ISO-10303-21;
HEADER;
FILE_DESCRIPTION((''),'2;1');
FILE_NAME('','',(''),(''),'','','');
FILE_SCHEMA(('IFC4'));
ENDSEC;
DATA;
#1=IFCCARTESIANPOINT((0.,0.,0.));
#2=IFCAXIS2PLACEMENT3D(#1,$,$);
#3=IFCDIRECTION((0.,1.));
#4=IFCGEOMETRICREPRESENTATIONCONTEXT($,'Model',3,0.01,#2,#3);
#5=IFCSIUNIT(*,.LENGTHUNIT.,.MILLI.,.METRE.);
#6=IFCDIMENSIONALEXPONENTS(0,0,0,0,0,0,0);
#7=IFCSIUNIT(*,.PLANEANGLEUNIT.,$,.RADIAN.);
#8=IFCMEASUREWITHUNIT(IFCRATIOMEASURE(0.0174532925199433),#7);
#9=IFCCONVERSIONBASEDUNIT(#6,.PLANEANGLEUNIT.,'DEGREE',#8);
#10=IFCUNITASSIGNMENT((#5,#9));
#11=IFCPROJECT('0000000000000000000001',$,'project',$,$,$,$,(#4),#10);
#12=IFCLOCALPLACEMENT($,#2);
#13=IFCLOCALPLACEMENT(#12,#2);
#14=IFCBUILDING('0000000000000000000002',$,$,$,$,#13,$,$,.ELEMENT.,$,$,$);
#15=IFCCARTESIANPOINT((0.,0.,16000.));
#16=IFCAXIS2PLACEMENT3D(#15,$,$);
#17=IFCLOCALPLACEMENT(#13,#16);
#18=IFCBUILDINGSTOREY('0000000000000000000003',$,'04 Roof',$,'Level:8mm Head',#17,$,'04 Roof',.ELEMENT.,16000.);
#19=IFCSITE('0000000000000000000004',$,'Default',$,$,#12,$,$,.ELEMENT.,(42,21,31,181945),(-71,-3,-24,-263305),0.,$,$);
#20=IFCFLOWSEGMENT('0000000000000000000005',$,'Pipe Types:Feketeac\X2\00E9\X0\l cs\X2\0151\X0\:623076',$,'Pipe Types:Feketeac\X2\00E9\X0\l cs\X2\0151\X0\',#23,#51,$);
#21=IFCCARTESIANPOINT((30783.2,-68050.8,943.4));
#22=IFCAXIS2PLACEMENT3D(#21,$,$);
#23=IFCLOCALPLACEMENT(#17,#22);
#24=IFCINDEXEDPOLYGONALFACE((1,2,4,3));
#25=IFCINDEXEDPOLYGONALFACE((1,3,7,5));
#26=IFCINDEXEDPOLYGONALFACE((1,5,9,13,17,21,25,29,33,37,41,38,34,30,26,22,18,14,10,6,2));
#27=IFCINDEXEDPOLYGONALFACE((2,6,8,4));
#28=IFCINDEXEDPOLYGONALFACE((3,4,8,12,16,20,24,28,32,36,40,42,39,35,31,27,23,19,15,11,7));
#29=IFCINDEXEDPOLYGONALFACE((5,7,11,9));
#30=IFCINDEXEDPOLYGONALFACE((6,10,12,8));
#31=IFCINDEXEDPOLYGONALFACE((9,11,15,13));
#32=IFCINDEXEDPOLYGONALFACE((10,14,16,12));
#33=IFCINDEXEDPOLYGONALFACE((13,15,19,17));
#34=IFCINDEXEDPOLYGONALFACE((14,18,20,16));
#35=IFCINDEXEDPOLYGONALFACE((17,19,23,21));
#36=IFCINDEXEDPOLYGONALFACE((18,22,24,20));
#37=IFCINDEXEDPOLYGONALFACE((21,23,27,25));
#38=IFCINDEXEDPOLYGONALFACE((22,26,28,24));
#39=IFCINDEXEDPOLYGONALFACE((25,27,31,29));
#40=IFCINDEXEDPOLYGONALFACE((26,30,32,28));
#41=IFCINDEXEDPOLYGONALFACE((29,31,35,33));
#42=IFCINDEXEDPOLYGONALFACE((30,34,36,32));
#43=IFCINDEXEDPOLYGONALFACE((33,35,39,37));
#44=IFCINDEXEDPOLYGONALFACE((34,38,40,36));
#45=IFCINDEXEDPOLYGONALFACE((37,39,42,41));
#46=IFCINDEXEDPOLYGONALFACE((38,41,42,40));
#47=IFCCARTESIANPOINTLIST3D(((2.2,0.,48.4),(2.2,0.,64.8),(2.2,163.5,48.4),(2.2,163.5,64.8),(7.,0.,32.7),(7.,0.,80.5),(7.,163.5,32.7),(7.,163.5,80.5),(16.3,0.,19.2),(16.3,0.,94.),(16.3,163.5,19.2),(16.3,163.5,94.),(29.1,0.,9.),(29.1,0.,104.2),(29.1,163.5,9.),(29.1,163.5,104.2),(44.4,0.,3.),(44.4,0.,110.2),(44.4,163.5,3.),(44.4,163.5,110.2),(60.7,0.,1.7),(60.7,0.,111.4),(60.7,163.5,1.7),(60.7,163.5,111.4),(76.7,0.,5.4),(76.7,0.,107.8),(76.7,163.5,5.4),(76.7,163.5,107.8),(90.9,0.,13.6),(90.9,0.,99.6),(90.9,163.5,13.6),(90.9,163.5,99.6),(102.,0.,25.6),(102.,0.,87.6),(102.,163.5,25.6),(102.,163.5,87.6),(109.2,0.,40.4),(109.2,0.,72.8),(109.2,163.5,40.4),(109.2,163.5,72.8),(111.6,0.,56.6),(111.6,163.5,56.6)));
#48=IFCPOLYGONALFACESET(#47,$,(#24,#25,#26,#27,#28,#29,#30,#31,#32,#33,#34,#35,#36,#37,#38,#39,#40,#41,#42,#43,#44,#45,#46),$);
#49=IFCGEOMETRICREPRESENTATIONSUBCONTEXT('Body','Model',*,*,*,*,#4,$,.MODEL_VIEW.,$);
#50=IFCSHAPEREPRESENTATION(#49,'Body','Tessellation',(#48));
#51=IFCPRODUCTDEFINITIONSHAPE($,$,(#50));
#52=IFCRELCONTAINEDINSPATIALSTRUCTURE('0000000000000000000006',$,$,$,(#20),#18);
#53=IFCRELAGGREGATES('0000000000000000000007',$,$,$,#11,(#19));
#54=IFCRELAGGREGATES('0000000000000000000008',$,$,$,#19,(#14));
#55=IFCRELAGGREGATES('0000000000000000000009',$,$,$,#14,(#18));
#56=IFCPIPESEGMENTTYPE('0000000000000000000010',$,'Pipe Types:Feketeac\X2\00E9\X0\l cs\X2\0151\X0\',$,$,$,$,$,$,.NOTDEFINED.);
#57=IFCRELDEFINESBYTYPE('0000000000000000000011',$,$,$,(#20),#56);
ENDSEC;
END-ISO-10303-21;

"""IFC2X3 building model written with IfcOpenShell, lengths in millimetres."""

from ifc_helpers import new_model, entity, si_unit, converted_unit, direction, frame, origin, origin_2d_with_axis, place, context, subcontext, project, spatial, circle, extrude, type_object, element, save


model = new_model("IFC2X3")

# Units and contexts
model_context = context("Model", 3, precision=0.01, world=origin(), true_north=direction((0.0, 1.0)))
body_context = subcontext(model_context, "Body", "Model", "MODEL_VIEW")
ifc_project = project(units=[si_unit("LENGTHUNIT", "METRE", prefix="MILLI"), converted_unit("PLANEANGLEUNIT", "DEGREE", entity("IfcRatioMeasure", 0.0174532925199433), si_unit("PLANEANGLEUNIT", "RADIAN"), dimensions=[0, 0, 0, 0, 0, 0, 0])], contexts=[model_context])

# Site, building, storey
site_placement = place(None, origin())
site = spatial("IfcSite", under=ifc_project, at=site_placement, Name="Default", CompositionType="ELEMENT", RefLatitude=(42, 21, 31, 181945), RefLongitude=(-71, -3, -24, -263305), RefElevation=0.0)
building_placement = place(site_placement, origin())
building = spatial("IfcBuilding", under=site, at=building_placement, CompositionType="ELEMENT")
storey_placement = place(building_placement, frame((0.0, 0.0, 16000.0)))
storey = spatial("IfcBuildingStorey", under=building, at=storey_placement, Name="04 Roof", ObjectType="Level:8mm Head", LongName="04 Roof", CompositionType="ELEMENT", Elevation=16000.0)

# Flow segment
pipe_segment_type = type_object("IfcPipeSegmentType", Name="Pipe Types:Feketeacél cső", PredefinedType="NOTDEFINED")
flow_segment_placement = place(storey_placement, frame((30783.2, -68050.8, 943.4)))
element("IfcFlowSegment", 1, at=flow_segment_placement, inside=storey, type_object=pipe_segment_type, Name="Pipe Types:Feketeacél cső:623076", ObjectType="Pipe Types:Feketeacél cső", context=body_context, shape_type="SweptSolid", body=[
    extrude(circle(Radius=55.0, at=origin_2d_with_axis()), frame((56.6, 0.0, 56.6), z_axis=(0.0, 1.0, 0.0), x_axis=(1.0, 0.0, 0.0)), (0.0, 0.0, 1.0), 163.5),
])

save(model, "model.ifc")
